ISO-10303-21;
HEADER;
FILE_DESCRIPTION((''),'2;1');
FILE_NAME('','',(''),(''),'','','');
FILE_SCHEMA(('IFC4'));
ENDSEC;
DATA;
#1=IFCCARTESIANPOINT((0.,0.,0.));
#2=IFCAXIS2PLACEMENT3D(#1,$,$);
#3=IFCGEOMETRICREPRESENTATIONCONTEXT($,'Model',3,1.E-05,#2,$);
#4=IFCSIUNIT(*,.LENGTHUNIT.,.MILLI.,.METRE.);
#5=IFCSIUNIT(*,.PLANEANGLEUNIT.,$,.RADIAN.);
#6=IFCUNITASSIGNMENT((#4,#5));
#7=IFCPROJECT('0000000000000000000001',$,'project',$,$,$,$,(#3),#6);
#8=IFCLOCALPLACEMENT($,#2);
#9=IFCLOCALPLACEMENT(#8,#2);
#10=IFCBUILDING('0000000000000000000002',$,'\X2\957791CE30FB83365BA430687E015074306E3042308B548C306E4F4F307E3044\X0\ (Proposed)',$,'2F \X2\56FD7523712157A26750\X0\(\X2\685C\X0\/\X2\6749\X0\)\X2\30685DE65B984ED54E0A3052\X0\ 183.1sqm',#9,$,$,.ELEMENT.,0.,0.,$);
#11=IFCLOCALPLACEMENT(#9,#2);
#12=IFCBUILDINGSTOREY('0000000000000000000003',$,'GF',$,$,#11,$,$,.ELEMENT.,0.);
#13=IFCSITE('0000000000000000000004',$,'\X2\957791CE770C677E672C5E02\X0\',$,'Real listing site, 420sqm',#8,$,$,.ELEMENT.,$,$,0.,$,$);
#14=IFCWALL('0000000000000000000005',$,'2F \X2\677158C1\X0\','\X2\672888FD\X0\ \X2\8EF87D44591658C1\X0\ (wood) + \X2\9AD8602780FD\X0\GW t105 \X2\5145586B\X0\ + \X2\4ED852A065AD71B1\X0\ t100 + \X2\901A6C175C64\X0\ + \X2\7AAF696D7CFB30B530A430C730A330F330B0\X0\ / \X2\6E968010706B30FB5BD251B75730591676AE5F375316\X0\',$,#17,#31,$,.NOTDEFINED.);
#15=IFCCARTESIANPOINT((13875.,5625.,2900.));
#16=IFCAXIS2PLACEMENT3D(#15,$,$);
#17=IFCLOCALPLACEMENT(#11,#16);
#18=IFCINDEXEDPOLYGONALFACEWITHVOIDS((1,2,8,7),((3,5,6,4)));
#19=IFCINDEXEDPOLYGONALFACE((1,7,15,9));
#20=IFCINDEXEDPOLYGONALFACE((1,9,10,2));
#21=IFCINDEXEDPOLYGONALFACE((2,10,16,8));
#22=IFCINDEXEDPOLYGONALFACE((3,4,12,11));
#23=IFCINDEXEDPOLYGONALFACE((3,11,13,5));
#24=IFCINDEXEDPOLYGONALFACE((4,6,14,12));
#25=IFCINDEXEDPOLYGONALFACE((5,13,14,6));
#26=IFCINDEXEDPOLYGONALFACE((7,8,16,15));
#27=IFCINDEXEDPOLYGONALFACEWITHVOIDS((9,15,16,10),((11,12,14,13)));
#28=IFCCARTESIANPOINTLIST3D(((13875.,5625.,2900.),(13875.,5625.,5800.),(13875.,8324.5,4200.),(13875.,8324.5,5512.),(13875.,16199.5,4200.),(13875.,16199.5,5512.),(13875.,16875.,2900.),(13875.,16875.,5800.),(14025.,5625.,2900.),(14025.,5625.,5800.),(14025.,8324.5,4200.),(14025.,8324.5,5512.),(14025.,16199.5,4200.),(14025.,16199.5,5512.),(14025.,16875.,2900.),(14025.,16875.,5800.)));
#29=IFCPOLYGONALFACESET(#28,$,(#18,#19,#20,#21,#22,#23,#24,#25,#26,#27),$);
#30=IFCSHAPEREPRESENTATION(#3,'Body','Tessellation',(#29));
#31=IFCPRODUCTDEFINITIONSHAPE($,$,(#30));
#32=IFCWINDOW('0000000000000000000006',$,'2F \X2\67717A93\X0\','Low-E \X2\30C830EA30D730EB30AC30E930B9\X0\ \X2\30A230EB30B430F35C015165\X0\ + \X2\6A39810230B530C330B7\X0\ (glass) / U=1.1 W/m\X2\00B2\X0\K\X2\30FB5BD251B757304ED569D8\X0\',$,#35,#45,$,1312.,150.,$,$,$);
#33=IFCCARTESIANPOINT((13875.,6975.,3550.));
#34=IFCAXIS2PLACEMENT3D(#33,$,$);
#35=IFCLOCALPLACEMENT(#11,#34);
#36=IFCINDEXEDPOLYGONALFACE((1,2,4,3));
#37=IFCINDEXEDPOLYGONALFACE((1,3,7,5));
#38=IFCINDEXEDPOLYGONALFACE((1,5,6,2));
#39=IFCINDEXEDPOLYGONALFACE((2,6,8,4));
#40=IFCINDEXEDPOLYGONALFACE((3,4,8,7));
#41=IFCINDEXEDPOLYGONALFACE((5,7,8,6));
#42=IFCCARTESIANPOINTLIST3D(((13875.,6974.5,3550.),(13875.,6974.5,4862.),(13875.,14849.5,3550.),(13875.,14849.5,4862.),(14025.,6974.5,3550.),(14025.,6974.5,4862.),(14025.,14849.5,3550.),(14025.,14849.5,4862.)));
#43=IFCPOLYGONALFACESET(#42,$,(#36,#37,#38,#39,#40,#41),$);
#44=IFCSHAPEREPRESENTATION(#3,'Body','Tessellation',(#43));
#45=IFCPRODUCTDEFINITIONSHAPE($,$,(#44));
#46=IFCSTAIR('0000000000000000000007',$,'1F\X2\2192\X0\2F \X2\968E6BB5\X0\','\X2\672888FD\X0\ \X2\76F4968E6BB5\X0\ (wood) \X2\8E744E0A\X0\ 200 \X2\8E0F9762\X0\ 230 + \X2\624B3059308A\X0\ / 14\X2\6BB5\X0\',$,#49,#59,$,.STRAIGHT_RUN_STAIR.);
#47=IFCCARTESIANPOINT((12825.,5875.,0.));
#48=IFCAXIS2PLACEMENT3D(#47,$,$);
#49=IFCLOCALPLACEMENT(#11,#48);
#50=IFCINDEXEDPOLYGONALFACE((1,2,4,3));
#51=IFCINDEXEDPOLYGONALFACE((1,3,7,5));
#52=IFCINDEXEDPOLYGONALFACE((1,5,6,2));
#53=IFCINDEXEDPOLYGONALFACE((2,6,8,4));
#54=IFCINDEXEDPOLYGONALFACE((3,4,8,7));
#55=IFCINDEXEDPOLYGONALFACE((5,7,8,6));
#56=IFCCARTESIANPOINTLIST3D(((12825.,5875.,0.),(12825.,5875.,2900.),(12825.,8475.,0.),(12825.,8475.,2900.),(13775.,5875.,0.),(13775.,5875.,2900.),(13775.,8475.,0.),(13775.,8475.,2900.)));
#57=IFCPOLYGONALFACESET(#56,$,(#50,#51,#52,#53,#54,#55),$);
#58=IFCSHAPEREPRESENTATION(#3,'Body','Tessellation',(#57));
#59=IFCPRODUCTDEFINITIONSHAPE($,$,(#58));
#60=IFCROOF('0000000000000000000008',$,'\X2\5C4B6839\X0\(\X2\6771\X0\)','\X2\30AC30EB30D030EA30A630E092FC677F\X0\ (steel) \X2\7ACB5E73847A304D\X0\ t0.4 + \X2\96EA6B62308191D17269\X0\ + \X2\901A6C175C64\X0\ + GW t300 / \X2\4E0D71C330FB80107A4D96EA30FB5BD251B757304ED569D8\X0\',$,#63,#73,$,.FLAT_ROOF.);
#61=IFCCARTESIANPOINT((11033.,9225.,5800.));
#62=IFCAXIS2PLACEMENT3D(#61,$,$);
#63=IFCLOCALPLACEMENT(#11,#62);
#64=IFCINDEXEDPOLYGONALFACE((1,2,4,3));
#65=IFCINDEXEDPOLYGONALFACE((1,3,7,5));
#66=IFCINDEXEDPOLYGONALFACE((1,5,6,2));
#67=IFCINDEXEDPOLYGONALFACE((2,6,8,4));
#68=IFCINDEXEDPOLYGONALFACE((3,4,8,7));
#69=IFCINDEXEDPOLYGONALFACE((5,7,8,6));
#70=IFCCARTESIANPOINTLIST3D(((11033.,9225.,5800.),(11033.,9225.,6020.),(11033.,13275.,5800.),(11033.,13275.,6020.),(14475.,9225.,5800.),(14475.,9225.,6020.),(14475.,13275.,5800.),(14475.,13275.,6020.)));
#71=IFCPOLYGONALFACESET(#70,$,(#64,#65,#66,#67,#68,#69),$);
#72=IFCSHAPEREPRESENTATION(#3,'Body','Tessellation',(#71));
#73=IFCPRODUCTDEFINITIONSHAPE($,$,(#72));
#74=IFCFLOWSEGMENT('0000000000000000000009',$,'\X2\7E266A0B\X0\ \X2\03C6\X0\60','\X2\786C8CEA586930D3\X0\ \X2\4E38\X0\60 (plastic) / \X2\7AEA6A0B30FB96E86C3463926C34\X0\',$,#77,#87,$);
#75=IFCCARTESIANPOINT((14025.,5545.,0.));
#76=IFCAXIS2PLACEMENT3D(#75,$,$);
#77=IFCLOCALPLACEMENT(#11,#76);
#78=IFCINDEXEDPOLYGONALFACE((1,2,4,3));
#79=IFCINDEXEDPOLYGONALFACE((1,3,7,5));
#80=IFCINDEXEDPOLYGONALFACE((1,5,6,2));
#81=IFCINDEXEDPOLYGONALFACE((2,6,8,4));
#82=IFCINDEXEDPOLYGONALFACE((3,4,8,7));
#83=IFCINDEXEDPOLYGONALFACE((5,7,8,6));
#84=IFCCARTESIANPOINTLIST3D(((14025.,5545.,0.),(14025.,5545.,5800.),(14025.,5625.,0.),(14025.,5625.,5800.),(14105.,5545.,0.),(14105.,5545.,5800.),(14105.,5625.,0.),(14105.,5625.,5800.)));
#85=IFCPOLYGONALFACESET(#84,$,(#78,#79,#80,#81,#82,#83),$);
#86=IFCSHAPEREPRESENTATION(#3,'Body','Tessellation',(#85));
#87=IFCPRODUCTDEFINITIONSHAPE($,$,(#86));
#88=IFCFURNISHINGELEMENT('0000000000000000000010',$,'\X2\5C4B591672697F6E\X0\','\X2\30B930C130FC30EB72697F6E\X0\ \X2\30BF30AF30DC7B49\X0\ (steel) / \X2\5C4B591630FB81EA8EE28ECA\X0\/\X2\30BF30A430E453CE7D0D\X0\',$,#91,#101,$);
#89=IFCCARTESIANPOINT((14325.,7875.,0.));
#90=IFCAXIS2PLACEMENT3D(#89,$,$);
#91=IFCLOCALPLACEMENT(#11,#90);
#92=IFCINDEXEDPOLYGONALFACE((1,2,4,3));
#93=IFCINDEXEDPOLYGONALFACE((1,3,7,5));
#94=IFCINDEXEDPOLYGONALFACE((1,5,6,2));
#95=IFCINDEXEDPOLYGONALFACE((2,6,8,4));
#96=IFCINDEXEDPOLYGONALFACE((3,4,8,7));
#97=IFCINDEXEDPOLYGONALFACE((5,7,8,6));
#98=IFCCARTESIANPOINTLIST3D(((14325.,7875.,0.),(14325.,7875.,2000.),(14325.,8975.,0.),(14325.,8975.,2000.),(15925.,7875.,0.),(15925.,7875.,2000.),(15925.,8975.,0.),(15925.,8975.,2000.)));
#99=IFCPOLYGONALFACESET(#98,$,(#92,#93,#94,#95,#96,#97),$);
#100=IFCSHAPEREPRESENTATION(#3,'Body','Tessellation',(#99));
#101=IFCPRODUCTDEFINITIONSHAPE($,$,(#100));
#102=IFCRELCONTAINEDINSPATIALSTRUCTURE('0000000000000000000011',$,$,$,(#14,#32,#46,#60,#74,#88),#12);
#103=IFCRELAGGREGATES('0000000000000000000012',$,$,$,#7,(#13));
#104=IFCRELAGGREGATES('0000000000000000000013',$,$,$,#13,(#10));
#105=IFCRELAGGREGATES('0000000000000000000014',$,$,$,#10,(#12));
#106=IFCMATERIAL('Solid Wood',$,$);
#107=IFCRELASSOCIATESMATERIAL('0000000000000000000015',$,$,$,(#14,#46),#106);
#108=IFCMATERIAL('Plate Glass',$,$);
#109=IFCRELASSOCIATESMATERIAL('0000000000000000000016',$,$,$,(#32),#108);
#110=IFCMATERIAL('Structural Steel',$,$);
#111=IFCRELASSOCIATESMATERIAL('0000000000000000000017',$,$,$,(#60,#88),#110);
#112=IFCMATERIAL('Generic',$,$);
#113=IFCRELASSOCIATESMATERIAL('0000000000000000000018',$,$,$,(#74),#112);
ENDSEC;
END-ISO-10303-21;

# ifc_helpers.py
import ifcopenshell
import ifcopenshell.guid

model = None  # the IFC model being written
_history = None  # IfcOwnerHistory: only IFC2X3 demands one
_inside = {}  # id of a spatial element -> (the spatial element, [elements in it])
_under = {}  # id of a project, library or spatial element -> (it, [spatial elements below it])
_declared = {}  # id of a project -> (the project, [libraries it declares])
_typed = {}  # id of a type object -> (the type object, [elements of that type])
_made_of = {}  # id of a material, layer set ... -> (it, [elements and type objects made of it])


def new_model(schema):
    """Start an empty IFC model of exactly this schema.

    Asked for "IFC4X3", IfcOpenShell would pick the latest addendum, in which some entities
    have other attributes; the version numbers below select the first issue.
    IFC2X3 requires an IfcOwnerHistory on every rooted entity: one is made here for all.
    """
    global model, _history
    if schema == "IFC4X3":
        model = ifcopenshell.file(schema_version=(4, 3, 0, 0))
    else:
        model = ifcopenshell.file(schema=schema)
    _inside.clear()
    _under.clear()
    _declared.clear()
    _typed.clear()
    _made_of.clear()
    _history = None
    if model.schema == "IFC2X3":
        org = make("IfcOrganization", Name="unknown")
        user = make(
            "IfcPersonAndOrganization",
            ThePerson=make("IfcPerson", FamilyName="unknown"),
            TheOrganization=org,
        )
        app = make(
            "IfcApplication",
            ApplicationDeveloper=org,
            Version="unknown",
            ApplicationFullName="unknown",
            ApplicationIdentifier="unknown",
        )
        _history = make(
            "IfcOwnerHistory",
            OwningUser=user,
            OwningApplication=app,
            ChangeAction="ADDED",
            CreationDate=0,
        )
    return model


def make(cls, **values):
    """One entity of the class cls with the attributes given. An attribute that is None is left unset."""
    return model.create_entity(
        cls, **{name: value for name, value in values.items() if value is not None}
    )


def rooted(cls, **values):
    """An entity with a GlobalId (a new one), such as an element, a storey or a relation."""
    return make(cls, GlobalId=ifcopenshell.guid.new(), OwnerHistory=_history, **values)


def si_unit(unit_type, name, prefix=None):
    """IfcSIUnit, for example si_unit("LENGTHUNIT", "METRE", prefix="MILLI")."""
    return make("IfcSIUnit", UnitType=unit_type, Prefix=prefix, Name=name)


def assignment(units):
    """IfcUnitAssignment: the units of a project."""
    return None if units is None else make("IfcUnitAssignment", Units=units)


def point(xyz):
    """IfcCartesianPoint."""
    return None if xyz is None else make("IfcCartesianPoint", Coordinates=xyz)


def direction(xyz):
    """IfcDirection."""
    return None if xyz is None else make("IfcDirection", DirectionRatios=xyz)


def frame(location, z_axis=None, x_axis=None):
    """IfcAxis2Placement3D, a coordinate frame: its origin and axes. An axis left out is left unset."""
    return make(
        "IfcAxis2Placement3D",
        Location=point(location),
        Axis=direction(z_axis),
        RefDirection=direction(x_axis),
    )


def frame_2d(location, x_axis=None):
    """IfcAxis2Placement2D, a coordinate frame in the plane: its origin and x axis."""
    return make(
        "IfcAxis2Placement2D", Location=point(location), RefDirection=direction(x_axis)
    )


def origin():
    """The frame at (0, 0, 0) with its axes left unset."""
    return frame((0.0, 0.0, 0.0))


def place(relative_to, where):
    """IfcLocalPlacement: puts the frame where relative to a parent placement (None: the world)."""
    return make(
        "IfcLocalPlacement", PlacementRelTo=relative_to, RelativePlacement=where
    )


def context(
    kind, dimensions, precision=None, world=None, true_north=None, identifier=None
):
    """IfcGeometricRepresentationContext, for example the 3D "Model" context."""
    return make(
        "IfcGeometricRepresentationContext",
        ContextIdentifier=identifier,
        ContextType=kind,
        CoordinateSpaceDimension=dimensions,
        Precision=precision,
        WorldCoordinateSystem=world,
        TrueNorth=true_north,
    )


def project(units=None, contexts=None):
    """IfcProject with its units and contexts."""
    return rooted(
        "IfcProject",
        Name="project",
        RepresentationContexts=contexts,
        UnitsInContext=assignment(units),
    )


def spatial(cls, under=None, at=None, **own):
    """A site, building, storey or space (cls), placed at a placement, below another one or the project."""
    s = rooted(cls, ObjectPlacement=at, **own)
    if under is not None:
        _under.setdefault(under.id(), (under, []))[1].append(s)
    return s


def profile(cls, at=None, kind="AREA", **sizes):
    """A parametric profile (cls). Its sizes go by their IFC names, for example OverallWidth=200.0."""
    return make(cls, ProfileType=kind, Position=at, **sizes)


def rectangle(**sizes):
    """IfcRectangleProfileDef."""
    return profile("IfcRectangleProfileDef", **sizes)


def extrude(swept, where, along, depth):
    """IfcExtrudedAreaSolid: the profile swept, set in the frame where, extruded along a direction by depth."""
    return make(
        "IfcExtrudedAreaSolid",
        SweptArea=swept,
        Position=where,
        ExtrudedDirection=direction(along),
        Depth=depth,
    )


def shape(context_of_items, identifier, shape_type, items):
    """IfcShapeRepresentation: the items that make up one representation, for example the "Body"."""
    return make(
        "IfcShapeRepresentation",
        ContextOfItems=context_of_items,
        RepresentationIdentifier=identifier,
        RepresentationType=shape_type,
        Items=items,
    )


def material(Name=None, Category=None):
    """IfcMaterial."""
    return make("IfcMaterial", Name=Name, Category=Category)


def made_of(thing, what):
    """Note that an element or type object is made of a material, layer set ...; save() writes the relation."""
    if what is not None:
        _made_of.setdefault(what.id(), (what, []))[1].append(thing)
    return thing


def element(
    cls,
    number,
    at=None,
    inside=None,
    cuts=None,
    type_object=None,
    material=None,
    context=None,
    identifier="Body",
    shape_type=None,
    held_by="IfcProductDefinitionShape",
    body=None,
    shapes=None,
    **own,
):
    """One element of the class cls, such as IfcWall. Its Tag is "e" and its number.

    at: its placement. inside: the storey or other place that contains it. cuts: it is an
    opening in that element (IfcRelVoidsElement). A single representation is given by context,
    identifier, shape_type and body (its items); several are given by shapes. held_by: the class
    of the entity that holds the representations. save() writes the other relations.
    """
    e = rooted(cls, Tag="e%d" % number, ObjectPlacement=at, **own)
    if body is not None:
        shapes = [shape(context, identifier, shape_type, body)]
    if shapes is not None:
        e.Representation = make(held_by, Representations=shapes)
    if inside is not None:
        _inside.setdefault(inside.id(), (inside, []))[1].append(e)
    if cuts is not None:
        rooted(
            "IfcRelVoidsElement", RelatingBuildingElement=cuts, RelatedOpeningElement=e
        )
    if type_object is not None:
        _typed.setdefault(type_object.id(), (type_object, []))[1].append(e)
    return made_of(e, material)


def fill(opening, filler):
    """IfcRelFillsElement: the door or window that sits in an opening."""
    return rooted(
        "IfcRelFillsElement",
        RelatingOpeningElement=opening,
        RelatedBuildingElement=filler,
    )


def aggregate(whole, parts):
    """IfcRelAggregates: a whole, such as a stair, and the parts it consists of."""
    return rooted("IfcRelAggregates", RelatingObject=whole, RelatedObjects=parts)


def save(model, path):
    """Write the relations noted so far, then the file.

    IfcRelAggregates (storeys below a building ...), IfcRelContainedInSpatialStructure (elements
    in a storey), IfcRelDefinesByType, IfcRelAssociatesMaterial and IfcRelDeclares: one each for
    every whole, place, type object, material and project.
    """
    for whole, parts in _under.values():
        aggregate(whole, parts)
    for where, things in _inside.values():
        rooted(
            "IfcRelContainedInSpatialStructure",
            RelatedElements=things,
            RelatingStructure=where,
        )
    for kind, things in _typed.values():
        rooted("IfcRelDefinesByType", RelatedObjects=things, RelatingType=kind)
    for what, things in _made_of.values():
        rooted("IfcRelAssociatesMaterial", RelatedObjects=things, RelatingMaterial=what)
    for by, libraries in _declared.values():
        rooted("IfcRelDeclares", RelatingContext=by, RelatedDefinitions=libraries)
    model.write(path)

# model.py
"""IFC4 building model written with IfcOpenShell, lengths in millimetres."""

from ifc_helpers import new_model, si_unit, frame, frame_2d, origin, place, context, project, spatial, rectangle, extrude, material, element, fill, save


model = new_model("IFC4")

# Units and contexts
model_context = context("Model", 3, precision=1e-05, world=origin())
ifc_project = project(units=[si_unit("LENGTHUNIT", "METRE", prefix="MILLI"), si_unit("PLANEANGLEUNIT", "RADIAN")], contexts=[model_context])

# Site, building, storey
site_placement = place(None, origin())
site = spatial("IfcSite", under=ifc_project, at=site_placement, Name="長野県松本市", ObjectType="Real listing site, 420sqm", CompositionType="ELEMENT", RefElevation=0.0)
building_placement = place(site_placement, origin())
building = spatial("IfcBuilding", under=site, at=building_placement, Name="長野・茶室と縁側のある和の住まい (Proposed)", ObjectType="2F 国産無垢材(桜/杉)と左官仕上げ 183.1sqm", CompositionType="ELEMENT", ElevationOfRefHeight=0.0, ElevationOfTerrain=0.0)
storey_placement = place(building_placement, origin())
storey = spatial("IfcBuildingStorey", under=building, at=storey_placement, Name="GF", CompositionType="ELEMENT", Elevation=0.0)

# Shared definitions
ifc_material_1 = material(Name="Solid Wood")

# Wall, opening, window
ifc_material_2 = material(Name="Plate Glass")
wall_1_placement = place(storey_placement, frame((13875.0, 5625.0, 2900.0)))
wall_1 = element("IfcWall", 1, at=wall_1_placement, inside=storey, material=ifc_material_1, Name="2F 東壁", Description="木製 軸組外壁 (wood) + 高性能GW t105 充填 + 付加断熱 t100 + 通気層 + 窯業系サイディング / 準耐火・寒冷地外皮強化", PredefinedType="NOTDEFINED", context=model_context, shape_type="SweptSolid", body=[
    extrude(rectangle(XDim=150.0, YDim=11250.0, at=frame_2d((75.0, 5625.0))), frame((13875.0, 5625.0, 2900.0)), (0.0, 0.0, 1.0), 2900.0),
])
opening_1_placement = place(storey_placement, frame((13875.0, 6975.0, 3550.0)))
opening_1 = element("IfcOpeningElement", 2, at=opening_1_placement, cuts=wall_1, PredefinedType="NOTDEFINED", context=model_context, shape_type="SweptSolid", body=[
    extrude(rectangle(XDim=150.0, YDim=7875.0, at=frame_2d((75.0, 3937.0))), frame((13875.0, 6975.0, 3550.0)), (0.0, 0.0, 1.0), 1312.0),
])
window_1_placement = place(storey_placement, frame((13875.0, 6975.0, 3550.0)))
window_1 = element("IfcWindow", 3, at=window_1_placement, inside=storey, material=ifc_material_2, Name="2F 東窓", Description="Low-E トリプルガラス アルゴン封入 + 樹脂サッシ (glass) / U=1.1 W/m²K・寒冷地仕様", OverallHeight=1312.0, OverallWidth=150.0, context=model_context, shape_type="SweptSolid", body=[
    extrude(rectangle(XDim=150.0, YDim=7875.0, at=frame_2d((75.0, 3937.0))), frame((13875.0, 6975.0, 3550.0)), (0.0, 0.0, 1.0), 1312.0),
])
fill(opening_1, window_1)

# Stair
stair_placement = place(storey_placement, frame((12825.0, 5875.0, 0.0)))
element("IfcStair", 4, at=stair_placement, inside=storey, material=ifc_material_1, Name="1F→2F 階段", Description="木製 直階段 (wood) 蹴上 200 踏面 230 + 手すり / 14段", PredefinedType="STRAIGHT_RUN_STAIR", context=model_context, shape_type="SweptSolid", body=[
    extrude(rectangle(XDim=950.0, YDim=2600.0, at=frame_2d((475.0, 1300.0))), frame((12825.0, 5875.0, 0.0)), (0.0, 0.0, 1.0), 2900.0),
])

# Roof
ifc_material_3 = material(Name="Structural Steel")
roof_placement = place(storey_placement, frame((11033.0, 9225.0, 5800.0)))
element("IfcRoof", 5, at=roof_placement, inside=storey, material=ifc_material_3, Name="屋根(東)", Description="ガルバリウム鋼板 (steel) 立平葺き t0.4 + 雪止め金物 + 通気層 + GW t300 / 不燃・耐積雪・寒冷地仕様", PredefinedType="FLAT_ROOF", context=model_context, shape_type="SweptSolid", body=[
    extrude(rectangle(XDim=3442.0, YDim=4050.0, at=frame_2d((1721.0, 2025.0))), frame((11033.0, 9225.0, 5800.0)), (0.0, 0.0, 1.0), 220.0),
])

# Flow segment
ifc_material_4 = material(Name="Generic")
flow_segment_placement = place(storey_placement, frame((14025.0, 5545.0, 0.0)))
element("IfcFlowSegment", 6, at=flow_segment_placement, inside=storey, material=ifc_material_4, Name="縦樋 φ60", Description="硬質塩ビ 丸60 (plastic) / 竪樋・雨水排水", context=model_context, shape_type="SweptSolid", body=[
    extrude(rectangle(XDim=80.0, YDim=80.0, at=frame_2d((40.0, 40.0))), frame((14025.0, 5545.0, 0.0)), (0.0, 0.0, 1.0), 5800.0),
])

# Furnishing element
furnishing_placement = place(storey_placement, frame((14325.0, 7875.0, 0.0)))
element("IfcFurnishingElement", 7, at=furnishing_placement, inside=storey, material=ifc_material_3, Name="屋外物置", Description="スチール物置 タクボ等 (steel) / 屋外・自転車/タイヤ収納", context=model_context, shape_type="SweptSolid", body=[
    extrude(rectangle(XDim=1600.0, YDim=1100.0, at=frame_2d((800.0, 550.0))), frame((14325.0, 7875.0, 0.0)), (0.0, 0.0, 1.0), 2000.0),
])

save(model, "model.ifc")
